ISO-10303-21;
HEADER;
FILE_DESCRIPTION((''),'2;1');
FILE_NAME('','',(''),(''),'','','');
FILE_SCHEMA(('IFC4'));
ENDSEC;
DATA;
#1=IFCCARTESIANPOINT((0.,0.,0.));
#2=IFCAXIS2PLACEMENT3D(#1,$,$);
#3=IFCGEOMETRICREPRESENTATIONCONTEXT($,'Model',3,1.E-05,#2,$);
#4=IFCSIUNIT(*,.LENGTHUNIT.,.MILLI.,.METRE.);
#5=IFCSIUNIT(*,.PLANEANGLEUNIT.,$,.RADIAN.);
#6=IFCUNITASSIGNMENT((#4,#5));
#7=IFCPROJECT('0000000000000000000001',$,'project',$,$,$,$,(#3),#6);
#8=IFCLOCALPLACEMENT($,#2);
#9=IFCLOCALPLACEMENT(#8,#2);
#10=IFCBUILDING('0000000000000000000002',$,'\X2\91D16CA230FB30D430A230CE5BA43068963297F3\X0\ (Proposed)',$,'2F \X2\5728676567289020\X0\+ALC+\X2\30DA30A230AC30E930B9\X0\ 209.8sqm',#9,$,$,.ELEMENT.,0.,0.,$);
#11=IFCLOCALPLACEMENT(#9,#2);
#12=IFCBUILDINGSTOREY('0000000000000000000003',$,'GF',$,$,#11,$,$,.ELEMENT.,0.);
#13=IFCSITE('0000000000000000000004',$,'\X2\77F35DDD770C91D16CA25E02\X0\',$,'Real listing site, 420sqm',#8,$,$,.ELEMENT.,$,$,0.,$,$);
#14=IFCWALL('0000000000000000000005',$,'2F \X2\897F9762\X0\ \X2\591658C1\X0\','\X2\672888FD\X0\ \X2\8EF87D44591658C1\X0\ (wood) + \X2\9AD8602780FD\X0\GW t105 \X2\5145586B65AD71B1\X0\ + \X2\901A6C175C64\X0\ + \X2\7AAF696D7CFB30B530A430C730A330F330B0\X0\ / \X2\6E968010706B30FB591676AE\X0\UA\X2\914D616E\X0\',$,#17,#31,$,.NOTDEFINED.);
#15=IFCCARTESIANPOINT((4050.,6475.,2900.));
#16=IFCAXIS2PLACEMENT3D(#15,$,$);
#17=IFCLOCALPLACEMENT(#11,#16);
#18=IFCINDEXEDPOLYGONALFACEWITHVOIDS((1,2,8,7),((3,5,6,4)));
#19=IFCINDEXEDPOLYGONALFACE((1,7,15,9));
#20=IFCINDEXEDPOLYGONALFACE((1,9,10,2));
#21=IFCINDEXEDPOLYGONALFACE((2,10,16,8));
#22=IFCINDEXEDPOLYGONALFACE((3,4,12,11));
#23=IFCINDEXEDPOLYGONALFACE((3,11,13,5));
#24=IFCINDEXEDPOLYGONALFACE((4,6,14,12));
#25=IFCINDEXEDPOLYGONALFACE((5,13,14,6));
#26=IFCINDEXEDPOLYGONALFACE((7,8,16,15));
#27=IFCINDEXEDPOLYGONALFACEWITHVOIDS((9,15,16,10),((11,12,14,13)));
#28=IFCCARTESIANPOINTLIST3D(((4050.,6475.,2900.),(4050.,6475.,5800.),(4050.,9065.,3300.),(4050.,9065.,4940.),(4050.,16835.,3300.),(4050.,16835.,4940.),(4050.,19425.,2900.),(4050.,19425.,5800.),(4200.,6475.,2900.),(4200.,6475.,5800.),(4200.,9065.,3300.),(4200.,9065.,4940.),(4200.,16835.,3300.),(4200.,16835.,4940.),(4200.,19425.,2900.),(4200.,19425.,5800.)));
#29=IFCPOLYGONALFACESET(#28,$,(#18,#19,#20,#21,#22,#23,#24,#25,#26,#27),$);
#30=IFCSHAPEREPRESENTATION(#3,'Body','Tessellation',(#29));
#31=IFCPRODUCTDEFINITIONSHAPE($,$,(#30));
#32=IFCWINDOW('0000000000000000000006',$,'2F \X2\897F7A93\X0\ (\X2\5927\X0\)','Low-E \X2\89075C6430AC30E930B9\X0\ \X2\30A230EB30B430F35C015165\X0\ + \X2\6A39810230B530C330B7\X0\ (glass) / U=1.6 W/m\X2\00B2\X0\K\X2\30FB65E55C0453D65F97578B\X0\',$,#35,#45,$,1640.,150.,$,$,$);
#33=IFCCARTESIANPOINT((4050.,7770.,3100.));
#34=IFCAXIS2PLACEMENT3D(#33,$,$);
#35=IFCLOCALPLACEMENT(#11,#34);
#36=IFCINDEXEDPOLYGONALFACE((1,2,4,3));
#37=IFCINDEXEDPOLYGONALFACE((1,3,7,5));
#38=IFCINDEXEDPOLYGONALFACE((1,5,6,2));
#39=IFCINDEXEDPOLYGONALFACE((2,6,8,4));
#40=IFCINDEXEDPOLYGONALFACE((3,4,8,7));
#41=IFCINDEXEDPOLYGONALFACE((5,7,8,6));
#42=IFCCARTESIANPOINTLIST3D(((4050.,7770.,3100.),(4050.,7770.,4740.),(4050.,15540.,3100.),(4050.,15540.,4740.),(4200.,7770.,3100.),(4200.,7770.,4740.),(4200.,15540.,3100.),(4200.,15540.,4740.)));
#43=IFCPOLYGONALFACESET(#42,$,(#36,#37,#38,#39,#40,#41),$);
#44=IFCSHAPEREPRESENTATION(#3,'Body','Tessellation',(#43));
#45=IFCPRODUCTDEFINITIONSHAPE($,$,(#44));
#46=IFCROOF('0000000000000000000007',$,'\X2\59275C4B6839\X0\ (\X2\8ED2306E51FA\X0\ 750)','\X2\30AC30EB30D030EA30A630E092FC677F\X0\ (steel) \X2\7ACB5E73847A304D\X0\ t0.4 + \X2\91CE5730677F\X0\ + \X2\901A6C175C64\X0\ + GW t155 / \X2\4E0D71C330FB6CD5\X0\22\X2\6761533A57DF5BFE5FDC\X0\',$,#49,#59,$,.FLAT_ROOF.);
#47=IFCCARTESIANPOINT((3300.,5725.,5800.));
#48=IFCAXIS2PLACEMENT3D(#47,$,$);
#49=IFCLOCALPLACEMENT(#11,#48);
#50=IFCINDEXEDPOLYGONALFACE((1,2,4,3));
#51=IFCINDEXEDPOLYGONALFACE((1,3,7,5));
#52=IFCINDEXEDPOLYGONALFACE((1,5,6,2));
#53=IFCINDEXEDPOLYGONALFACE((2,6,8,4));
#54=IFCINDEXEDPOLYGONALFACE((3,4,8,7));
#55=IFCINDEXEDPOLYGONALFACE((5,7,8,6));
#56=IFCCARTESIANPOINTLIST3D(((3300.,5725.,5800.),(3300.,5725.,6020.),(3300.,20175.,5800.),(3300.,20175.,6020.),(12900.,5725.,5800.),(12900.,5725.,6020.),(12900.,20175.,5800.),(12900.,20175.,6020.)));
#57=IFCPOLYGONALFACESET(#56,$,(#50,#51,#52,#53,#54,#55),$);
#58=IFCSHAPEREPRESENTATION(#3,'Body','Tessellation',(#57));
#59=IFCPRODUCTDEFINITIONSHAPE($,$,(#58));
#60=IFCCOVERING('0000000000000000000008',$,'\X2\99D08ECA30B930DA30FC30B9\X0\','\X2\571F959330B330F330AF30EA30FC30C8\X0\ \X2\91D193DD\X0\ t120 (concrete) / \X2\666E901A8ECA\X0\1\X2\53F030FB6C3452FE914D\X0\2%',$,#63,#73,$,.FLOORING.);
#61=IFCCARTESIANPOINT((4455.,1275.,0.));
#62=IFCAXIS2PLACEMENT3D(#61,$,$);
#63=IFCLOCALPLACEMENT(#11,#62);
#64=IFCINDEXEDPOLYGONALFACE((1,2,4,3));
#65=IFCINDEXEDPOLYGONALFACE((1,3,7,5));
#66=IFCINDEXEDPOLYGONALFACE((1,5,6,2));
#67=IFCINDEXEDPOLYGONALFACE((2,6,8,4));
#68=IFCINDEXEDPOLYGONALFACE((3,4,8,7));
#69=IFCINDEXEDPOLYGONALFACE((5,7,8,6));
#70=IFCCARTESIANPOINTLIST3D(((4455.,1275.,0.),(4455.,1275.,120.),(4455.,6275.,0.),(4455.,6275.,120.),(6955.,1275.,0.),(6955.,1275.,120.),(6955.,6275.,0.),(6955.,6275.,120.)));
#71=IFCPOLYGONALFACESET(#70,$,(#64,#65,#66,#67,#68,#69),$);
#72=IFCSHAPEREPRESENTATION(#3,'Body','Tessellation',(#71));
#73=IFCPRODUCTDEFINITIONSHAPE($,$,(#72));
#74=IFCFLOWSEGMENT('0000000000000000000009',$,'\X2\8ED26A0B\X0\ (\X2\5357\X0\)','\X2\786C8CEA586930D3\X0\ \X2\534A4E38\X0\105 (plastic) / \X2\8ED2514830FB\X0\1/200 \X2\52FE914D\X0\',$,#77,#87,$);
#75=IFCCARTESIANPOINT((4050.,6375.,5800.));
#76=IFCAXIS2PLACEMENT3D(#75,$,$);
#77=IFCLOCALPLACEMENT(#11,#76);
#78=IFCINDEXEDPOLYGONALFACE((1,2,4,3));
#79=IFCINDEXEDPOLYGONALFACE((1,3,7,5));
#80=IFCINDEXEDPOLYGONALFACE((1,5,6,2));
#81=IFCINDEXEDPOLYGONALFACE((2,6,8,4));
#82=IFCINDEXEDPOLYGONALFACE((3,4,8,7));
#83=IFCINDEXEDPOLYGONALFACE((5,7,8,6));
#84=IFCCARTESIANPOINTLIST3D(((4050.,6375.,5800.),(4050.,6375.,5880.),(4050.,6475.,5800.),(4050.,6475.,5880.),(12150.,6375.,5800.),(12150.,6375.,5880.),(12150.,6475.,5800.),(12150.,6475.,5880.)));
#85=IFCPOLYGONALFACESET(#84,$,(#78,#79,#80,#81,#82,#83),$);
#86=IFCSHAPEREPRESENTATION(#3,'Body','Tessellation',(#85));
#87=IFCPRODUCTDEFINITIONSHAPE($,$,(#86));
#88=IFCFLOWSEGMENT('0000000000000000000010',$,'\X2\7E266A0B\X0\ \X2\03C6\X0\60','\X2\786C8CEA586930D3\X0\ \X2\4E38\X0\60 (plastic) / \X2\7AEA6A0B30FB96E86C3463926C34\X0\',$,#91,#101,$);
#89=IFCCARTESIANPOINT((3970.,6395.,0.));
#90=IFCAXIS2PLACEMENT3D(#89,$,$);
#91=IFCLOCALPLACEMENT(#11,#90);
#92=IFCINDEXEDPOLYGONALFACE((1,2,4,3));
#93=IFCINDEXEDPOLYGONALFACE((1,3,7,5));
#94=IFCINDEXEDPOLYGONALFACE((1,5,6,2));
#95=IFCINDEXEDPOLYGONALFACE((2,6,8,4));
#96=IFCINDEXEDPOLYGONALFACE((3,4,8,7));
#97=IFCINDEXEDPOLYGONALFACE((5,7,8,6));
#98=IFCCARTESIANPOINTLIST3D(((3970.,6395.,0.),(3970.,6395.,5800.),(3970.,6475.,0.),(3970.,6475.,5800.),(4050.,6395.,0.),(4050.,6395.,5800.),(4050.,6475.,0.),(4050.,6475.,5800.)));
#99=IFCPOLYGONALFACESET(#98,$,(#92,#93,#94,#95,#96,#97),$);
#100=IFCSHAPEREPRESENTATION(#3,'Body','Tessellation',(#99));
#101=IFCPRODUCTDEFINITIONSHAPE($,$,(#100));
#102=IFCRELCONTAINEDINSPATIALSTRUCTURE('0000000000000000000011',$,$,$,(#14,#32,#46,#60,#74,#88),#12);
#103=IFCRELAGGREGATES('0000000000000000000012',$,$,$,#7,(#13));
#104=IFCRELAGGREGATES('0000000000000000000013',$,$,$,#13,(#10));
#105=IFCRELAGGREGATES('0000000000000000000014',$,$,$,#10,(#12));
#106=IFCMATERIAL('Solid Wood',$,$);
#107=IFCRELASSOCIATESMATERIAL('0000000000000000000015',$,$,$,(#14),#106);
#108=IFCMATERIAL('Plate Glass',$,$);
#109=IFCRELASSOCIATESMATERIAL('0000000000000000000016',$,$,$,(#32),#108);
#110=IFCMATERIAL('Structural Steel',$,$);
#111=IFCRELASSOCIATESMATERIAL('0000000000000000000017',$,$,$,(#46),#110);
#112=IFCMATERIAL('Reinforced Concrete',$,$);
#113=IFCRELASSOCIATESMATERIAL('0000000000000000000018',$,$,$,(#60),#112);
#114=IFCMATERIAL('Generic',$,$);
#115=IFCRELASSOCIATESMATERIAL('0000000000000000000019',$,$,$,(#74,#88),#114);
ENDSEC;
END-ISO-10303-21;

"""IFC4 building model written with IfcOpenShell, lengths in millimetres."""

from ifc_helpers import new_model, si_unit, frame, frame_2d, origin, place, context, project, spatial, rectangle, extrude, material, element, fill, save


model = new_model("IFC4")

# Units and contexts
model_context = context("Model", 3, precision=1e-05, world=origin())
ifc_project = project(units=[si_unit("LENGTHUNIT", "METRE", prefix="MILLI"), si_unit("PLANEANGLEUNIT", "RADIAN")], contexts=[model_context])

# Site, building, storey
site_placement = place(None, origin())
site = spatial("IfcSite", under=ifc_project, at=site_placement, Name="石川県金沢市", ObjectType="Real listing site, 420sqm", CompositionType="ELEMENT", RefElevation=0.0)
building_placement = place(site_placement, origin())
building = spatial("IfcBuilding", under=site, at=building_placement, Name="金沢・ピアノ室と防音 (Proposed)", ObjectType="2F 在来木造+ALC+ペアガラス 209.8sqm", CompositionType="ELEMENT", ElevationOfRefHeight=0.0, ElevationOfTerrain=0.0)
storey_placement = place(building_placement, origin())
storey = spatial("IfcBuildingStorey", under=building, at=storey_placement, Name="GF", CompositionType="ELEMENT", Elevation=0.0)

# Shared definitions
ifc_material_1 = material(Name="Solid Wood")

# Shared definitions
ifc_material_2 = material(Name="Reinforced Concrete")

# Shared definitions
ifc_material_3 = material(Name="Plate Glass")

# Wall, opening, window
wall_1_placement = place(storey_placement, frame((4050.0, 6475.0, 2900.0)))
wall_1 = element("IfcWall", 1, at=wall_1_placement, inside=storey, material=ifc_material_1, Name="2F 西面 外壁", Description="木製 軸組外壁 (wood) + 高性能GW t105 充填断熱 + 通気層 + 窯業系サイディング / 準耐火・外皮UA配慮", PredefinedType="NOTDEFINED", context=model_context, shape_type="SweptSolid", body=[
    extrude(rectangle(XDim=150.0, YDim=12950.0, at=frame_2d((75.0, 6475.0))), frame((4050.0, 6475.0, 2900.0)), (0.0, 0.0, 1.0), 2900.0),
])
opening_1_placement = place(storey_placement, frame((4050.0, 7770.0, 3100.0)))
opening_1 = element("IfcOpeningElement", 2, at=opening_1_placement, cuts=wall_1, PredefinedType="NOTDEFINED", context=model_context, shape_type="SweptSolid", body=[
    extrude(rectangle(XDim=150.0, YDim=7770.0, at=frame_2d((75.0, 3885.0))), frame((4050.0, 7770.0, 3100.0)), (0.0, 0.0, 1.0), 1640.0),
])
window_1_placement = place(storey_placement, frame((4050.0, 7770.0, 3100.0)))
window_1 = element("IfcWindow", 3, at=window_1_placement, inside=storey, material=ifc_material_3, Name="2F 西窓 (大)", Description="Low-E 複層ガラス アルゴン封入 + 樹脂サッシ (glass) / U=1.6 W/m²K・日射取得型", OverallHeight=1640.0, OverallWidth=150.0, context=model_context, shape_type="SweptSolid", body=[
    extrude(rectangle(XDim=150.0, YDim=7770.0, at=frame_2d((75.0, 3885.0))), frame((4050.0, 7770.0, 3100.0)), (0.0, 0.0, 1.0), 1640.0),
])
fill(opening_1, window_1)

# Roof
ifc_material_4 = material(Name="Structural Steel")
roof_placement = place(storey_placement, frame((3300.0, 5725.0, 5800.0)))
element("IfcRoof", 4, at=roof_placement, inside=storey, material=ifc_material_4, Name="大屋根 (軒の出 750)", Description="ガルバリウム鋼板 (steel) 立平葺き t0.4 + 野地板 + 通気層 + GW t155 / 不燃・法22条区域対応", PredefinedType="FLAT_ROOF", context=model_context, shape_type="SweptSolid", body=[
    extrude(rectangle(XDim=9600.0, YDim=14450.0, at=frame_2d((4800.0, 7225.0))), frame((3300.0, 5725.0, 5800.0)), (0.0, 0.0, 1.0), 220.0),
])

# Covering
covering_placement = place(storey_placement, frame((4455.0, 1275.0, 0.0)))
element("IfcCovering", 5, at=covering_placement, inside=storey, material=ifc_material_2, Name="駐車スペース", Description="土間コンクリート 金鏝 t120 (concrete) / 普通車1台・水勾配2%", PredefinedType="FLOORING", context=model_context, shape_type="SweptSolid", body=[
    extrude(rectangle(XDim=2500.0, YDim=5000.0, at=frame_2d((1250.0, 2500.0))), frame((4455.0, 1275.0, 0.0)), (0.0, 0.0, 1.0), 120.0),
])

# Flow segments
ifc_material_5 = material(Name="Generic")
flow_segment_1_placement = place(storey_placement, frame((4050.0, 6375.0, 5800.0)))
element("IfcFlowSegment", 6, at=flow_segment_1_placement, inside=storey, material=ifc_material_5, Name="軒樋 (南)", Description="硬質塩ビ 半丸105 (plastic) / 軒先・1/200 勾配", context=model_context, shape_type="SweptSolid", body=[
    extrude(rectangle(XDim=8100.0, YDim=100.0, at=frame_2d((4050.0, 50.0))), frame((4050.0, 6375.0, 5800.0)), (0.0, 0.0, 1.0), 80.0),
])
flow_segment_2_placement = place(storey_placement, frame((3970.0, 6395.0, 0.0)))
element("IfcFlowSegment", 7, at=flow_segment_2_placement, inside=storey, material=ifc_material_5, Name="縦樋 φ60", Description="硬質塩ビ 丸60 (plastic) / 竪樋・雨水排水", context=model_context, shape_type="SweptSolid", body=[
    extrude(rectangle(XDim=80.0, YDim=80.0, at=frame_2d((40.0, 40.0))), frame((3970.0, 6395.0, 0.0)), (0.0, 0.0, 1.0), 5800.0),
])

save(model, "model.ifc")
